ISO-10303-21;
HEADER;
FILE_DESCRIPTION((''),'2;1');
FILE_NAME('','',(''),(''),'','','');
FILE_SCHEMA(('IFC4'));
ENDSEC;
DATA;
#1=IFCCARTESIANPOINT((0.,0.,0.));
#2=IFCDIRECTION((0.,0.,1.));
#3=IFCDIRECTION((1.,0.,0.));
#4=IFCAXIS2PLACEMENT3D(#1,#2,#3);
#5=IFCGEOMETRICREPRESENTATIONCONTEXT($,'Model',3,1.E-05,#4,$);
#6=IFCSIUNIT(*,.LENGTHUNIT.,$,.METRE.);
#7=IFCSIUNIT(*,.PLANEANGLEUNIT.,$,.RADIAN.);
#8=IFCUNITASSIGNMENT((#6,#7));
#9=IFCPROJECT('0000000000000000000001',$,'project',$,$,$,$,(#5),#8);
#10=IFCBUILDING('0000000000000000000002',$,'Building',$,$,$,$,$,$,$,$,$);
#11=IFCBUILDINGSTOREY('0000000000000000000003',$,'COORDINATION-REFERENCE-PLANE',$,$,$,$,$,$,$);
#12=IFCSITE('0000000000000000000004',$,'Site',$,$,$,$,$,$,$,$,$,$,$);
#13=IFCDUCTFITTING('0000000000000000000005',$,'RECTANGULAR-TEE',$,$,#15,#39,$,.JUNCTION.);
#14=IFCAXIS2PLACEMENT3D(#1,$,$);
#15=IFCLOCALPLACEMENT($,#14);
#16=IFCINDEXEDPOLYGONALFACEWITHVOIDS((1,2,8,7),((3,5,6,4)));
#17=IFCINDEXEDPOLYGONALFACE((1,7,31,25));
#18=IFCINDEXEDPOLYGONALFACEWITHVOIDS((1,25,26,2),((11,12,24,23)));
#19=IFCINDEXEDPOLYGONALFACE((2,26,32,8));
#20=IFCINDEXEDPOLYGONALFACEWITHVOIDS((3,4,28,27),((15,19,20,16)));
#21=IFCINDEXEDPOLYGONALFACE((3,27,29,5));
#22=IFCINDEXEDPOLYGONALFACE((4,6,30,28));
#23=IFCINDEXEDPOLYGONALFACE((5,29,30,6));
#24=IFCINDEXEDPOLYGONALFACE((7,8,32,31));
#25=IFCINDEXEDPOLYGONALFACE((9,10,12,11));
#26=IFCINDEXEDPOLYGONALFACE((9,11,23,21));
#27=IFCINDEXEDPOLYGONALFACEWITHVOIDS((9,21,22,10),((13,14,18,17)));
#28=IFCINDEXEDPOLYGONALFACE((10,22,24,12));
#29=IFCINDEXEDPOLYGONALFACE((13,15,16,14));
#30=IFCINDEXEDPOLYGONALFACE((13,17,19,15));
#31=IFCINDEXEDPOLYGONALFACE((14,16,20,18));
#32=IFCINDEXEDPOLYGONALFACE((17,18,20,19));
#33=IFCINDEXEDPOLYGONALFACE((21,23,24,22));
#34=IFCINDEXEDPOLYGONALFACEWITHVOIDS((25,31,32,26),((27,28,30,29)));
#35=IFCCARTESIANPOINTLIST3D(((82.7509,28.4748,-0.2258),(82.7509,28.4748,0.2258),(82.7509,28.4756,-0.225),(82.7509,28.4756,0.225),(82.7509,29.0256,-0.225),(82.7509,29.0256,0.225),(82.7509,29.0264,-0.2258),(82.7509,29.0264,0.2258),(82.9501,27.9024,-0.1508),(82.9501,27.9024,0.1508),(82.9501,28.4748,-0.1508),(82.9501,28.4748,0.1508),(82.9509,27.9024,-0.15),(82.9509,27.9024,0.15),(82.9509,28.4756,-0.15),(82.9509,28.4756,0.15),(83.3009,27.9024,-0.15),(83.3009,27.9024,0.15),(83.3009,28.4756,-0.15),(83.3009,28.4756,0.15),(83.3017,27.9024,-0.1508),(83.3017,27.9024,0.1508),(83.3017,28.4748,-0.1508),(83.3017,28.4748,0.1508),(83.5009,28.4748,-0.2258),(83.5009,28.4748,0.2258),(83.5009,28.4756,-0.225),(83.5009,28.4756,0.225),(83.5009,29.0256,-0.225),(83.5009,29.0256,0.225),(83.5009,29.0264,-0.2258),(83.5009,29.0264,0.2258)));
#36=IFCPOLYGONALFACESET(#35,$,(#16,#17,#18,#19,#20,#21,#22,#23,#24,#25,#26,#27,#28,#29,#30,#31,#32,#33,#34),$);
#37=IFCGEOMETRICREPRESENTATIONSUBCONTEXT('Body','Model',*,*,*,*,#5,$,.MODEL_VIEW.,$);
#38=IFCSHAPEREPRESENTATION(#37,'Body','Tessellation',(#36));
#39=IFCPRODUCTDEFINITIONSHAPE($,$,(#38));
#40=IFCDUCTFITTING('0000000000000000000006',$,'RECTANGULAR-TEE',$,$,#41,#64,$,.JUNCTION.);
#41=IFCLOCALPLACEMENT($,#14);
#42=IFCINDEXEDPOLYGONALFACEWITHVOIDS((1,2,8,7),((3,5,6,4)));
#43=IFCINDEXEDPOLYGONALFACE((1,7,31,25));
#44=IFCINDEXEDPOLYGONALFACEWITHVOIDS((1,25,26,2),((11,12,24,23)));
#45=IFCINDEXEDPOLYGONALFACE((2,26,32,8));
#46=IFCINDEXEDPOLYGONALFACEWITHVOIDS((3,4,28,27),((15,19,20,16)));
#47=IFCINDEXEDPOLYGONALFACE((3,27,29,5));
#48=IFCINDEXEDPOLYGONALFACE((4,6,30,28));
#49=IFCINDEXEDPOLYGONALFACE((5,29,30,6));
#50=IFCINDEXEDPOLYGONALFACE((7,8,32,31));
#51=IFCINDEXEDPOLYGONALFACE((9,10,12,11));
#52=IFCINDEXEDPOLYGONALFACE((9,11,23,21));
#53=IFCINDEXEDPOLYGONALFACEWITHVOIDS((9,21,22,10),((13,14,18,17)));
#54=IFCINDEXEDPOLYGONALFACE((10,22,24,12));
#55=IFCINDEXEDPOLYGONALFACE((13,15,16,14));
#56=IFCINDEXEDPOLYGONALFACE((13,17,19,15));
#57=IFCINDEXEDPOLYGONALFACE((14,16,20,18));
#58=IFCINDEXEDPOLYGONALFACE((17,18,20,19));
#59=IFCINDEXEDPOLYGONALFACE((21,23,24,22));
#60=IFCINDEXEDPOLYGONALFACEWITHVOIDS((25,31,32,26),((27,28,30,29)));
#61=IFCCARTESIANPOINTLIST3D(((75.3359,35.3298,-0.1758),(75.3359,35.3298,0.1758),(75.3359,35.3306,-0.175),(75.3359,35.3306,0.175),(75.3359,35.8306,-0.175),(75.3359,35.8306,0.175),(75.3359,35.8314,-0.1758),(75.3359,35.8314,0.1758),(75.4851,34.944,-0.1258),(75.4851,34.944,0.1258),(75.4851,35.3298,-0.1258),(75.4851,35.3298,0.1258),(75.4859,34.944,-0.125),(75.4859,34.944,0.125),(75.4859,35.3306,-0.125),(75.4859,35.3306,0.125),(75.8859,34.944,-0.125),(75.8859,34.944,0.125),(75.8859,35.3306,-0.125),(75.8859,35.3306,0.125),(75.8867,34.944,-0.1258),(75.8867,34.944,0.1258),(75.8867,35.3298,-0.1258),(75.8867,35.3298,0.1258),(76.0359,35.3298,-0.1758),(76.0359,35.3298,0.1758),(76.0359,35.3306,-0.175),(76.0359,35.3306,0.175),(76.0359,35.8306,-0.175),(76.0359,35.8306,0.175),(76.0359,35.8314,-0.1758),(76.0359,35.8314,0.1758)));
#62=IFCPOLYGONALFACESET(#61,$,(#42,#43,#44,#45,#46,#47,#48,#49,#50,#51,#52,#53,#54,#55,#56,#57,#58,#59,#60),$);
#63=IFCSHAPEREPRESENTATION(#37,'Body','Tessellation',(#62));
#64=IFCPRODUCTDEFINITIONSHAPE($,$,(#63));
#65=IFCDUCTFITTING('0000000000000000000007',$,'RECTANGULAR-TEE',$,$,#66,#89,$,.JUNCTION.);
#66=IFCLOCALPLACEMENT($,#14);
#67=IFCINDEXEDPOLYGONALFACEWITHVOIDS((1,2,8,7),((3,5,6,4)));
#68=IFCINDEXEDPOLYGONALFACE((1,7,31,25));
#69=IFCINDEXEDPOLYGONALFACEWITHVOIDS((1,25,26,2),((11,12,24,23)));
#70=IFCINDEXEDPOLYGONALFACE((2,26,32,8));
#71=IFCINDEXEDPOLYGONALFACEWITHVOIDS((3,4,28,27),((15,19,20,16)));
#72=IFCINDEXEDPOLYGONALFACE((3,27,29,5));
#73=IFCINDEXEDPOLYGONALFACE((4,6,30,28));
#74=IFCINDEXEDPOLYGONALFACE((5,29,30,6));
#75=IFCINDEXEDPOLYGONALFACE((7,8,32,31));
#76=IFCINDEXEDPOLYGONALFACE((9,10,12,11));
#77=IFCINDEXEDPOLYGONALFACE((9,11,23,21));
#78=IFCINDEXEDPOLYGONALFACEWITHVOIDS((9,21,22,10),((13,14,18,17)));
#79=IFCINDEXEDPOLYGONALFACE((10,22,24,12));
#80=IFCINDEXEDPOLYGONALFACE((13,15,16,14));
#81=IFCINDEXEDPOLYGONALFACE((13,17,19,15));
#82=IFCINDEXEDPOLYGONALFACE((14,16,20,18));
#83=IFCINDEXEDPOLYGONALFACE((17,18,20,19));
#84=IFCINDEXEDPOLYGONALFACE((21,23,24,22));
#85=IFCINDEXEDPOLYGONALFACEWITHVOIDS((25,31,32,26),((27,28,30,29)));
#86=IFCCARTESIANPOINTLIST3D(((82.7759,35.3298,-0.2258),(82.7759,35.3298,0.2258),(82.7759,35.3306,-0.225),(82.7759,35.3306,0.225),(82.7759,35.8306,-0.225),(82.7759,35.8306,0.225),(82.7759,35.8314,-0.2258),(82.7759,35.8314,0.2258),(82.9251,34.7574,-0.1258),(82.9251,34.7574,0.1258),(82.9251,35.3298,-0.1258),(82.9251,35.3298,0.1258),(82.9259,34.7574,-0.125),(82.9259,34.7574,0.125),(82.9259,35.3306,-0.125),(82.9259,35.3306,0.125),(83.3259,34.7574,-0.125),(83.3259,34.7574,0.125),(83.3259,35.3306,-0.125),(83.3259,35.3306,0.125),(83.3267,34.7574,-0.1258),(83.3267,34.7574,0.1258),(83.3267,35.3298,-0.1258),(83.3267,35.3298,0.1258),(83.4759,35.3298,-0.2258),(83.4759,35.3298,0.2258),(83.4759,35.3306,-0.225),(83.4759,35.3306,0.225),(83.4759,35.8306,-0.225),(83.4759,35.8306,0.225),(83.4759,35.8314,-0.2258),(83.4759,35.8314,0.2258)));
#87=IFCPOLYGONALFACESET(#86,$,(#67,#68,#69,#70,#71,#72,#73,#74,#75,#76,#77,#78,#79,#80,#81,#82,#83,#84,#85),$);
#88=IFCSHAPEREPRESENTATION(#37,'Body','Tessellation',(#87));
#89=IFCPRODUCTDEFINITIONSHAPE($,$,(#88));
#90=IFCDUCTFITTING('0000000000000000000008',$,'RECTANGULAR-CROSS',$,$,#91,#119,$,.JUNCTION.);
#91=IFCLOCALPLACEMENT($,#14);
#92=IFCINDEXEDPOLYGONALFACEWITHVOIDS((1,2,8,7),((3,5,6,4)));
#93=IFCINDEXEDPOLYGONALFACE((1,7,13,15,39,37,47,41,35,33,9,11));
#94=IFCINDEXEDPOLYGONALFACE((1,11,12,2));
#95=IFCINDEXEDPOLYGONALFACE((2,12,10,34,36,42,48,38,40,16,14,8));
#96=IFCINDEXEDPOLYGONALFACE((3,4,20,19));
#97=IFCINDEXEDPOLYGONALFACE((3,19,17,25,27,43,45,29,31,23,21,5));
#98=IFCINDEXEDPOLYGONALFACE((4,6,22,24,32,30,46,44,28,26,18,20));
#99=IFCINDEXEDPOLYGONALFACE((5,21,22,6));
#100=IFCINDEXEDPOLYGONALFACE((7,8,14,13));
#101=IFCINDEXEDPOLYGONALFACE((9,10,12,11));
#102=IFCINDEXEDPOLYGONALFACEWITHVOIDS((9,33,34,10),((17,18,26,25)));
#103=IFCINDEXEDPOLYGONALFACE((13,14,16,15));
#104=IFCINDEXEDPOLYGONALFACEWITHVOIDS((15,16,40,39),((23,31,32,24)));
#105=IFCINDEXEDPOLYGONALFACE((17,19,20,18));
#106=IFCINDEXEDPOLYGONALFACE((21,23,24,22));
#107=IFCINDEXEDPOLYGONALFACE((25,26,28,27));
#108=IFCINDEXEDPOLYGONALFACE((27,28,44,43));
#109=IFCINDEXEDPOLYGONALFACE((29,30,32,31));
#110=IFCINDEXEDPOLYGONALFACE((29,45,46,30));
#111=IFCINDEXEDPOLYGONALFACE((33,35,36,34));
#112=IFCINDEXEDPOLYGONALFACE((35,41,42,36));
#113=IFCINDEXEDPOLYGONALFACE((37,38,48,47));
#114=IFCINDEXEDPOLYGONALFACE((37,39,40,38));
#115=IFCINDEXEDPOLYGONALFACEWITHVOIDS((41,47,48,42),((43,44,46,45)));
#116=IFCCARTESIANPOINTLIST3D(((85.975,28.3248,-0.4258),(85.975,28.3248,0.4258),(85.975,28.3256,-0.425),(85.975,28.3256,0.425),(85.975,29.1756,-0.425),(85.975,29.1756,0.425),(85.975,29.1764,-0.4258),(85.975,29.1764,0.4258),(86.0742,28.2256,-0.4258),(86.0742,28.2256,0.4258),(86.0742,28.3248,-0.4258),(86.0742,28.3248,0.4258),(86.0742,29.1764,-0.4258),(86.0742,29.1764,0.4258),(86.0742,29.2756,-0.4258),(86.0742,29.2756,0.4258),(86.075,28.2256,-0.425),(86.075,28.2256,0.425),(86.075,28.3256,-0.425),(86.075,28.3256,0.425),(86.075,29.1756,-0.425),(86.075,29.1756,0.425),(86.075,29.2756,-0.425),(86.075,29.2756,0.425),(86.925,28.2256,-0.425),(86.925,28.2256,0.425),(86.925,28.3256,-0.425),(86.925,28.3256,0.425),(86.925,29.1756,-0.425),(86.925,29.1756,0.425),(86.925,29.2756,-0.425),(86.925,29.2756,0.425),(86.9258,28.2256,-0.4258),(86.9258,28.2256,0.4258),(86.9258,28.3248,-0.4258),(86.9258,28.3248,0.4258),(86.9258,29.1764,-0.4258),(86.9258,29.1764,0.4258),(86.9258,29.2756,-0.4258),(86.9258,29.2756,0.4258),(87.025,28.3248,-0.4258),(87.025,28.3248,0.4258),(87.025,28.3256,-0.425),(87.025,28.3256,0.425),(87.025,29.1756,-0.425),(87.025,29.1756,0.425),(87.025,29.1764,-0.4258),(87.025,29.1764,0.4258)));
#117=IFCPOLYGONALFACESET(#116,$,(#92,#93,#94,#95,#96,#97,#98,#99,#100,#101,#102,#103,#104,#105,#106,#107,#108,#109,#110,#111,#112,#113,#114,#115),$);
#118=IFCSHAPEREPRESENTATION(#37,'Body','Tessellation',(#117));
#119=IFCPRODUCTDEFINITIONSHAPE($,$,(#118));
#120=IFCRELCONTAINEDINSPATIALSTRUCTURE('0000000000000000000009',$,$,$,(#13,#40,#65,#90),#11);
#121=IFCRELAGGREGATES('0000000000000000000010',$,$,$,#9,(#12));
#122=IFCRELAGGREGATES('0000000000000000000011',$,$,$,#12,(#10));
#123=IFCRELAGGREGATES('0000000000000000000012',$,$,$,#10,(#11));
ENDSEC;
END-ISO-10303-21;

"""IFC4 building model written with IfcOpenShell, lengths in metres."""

from ifc_helpers import new_model, si_unit, frame, origin_with_axes, place, context, subcontext, project, spatial, rectangle, extrude, boolean, element, save


model = new_model("IFC4")

# Units and contexts
model_context = context("Model", 3, precision=1e-05, world=origin_with_axes())
body_context = subcontext(model_context, "Body", "Model", "MODEL_VIEW")
ifc_project = project(units=[si_unit("LENGTHUNIT", "METRE"), si_unit("PLANEANGLEUNIT", "RADIAN")], contexts=[model_context])

# Site, building, storey
site = spatial("IfcSite", under=ifc_project, Name="Site")
building = spatial("IfcBuilding", under=site, Name="Building")
storey = spatial("IfcBuildingStorey", under=building, Name="COORDINATION-REFERENCE-PLANE")

# Duct fittings
duct_fitting_1_placement = place(None, frame((83.1259, 28.7506, 0.0), z_axis=(-1.0, 0.0, 0.0), x_axis=(0.0, -1.0, 0.0)))
solid_1 = boolean("UNION", extrude(rectangle(XDim=0.55, YDim=0.45), frame((0.0, 0.0, -0.375), z_axis=(0.0, 0.0, 1.0), x_axis=(1.0, 0.0, 0.0)), (0.0, 0.0, 1.0), 0.75), extrude(rectangle(XDim=0.35, YDim=0.3), frame((0.0, 0.0, 0.0), z_axis=(1.0, 0.0, 0.0), x_axis=(0.0, 0.0, -1.0)), (0.0, 0.0, 1.0), 0.8482))
element("IfcDuctFitting", 1, at=duct_fitting_1_placement, inside=storey, Name="RECTANGULAR-TEE", PredefinedType="JUNCTION", context=body_context, shape_type="CSG", body=[
    boolean("DIFFERENCE", boolean("UNION", extrude(rectangle(XDim=0.5516, YDim=0.4516), frame((0.0, 0.0, -0.375), z_axis=(0.0, 0.0, 1.0), x_axis=(1.0, 0.0, 0.0)), (0.0, 0.0, 1.0), 0.75), extrude(rectangle(XDim=0.3516, YDim=0.3016), frame((0.0, 0.0, 0.0), z_axis=(1.0, 0.0, 0.0), x_axis=(0.0, 0.0, -1.0)), (0.0, 0.0, 1.0), 0.8482)), solid_1),
])
duct_fitting_2_placement = place(None, frame((75.6859, 35.5806, 0.0), z_axis=(-1.0, 0.0, 0.0), x_axis=(0.0, -1.0, 0.0)))
solid_2 = boolean("UNION", extrude(rectangle(XDim=0.5, YDim=0.35), frame((0.0, 0.0, -0.35), z_axis=(0.0, 0.0, 1.0), x_axis=(1.0, 0.0, 0.0)), (0.0, 0.0, 1.0), 0.7), extrude(rectangle(XDim=0.4, YDim=0.25), frame((0.0, 0.0, 0.0), z_axis=(1.0, 0.0, 0.0), x_axis=(0.0, 0.0, -1.0)), (0.0, 0.0, 1.0), 0.6366))
element("IfcDuctFitting", 2, at=duct_fitting_2_placement, inside=storey, Name="RECTANGULAR-TEE", PredefinedType="JUNCTION", context=body_context, shape_type="CSG", body=[
    boolean("DIFFERENCE", boolean("UNION", extrude(rectangle(XDim=0.5016, YDim=0.3516), frame((0.0, 0.0, -0.35), z_axis=(0.0, 0.0, 1.0), x_axis=(1.0, 0.0, 0.0)), (0.0, 0.0, 1.0), 0.7), extrude(rectangle(XDim=0.4016, YDim=0.2516), frame((0.0, 0.0, 0.0), z_axis=(1.0, 0.0, 0.0), x_axis=(0.0, 0.0, -1.0)), (0.0, 0.0, 1.0), 0.6366)), solid_2),
])
duct_fitting_3_placement = place(None, frame((83.1259, 35.5806, 0.0), z_axis=(-1.0, 0.0, 0.0), x_axis=(0.0, -1.0, 0.0)))
solid_3 = boolean("UNION", extrude(rectangle(XDim=0.5, YDim=0.45), frame((0.0, 0.0, -0.35), z_axis=(0.0, 0.0, 1.0), x_axis=(1.0, 0.0, 0.0)), (0.0, 0.0, 1.0), 0.7), extrude(rectangle(XDim=0.4, YDim=0.25), frame((0.0, 0.0, 0.0), z_axis=(1.0, 0.0, 0.0), x_axis=(0.0, 0.0, -1.0)), (0.0, 0.0, 1.0), 0.8232))
element("IfcDuctFitting", 3, at=duct_fitting_3_placement, inside=storey, Name="RECTANGULAR-TEE", PredefinedType="JUNCTION", context=body_context, shape_type="CSG", body=[
    boolean("DIFFERENCE", boolean("UNION", extrude(rectangle(XDim=0.5016, YDim=0.4516), frame((0.0, 0.0, -0.35), z_axis=(0.0, 0.0, 1.0), x_axis=(1.0, 0.0, 0.0)), (0.0, 0.0, 1.0), 0.7), extrude(rectangle(XDim=0.4016, YDim=0.2516), frame((0.0, 0.0, 0.0), z_axis=(1.0, 0.0, 0.0), x_axis=(0.0, 0.0, -1.0)), (0.0, 0.0, 1.0), 0.8232)), solid_3),
])
duct_fitting_4_placement = place(None, frame((86.5, 28.7506, 0.0), z_axis=(0.0, -1.0, 0.0), x_axis=(1.0, 0.0, 0.0)))
solid_4 = boolean("UNION", extrude(rectangle(XDim=0.85, YDim=0.85), frame((0.0, 0.0, -0.525), z_axis=(0.0, 0.0, 1.0), x_axis=(1.0, 0.0, 0.0)), (0.0, 0.0, 1.0), 1.05), extrude(rectangle(XDim=0.85, YDim=0.85), frame((-0.525, 0.0, 0.0), z_axis=(1.0, 0.0, 0.0), x_axis=(0.0, 0.0, -1.0)), (0.0, 0.0, 1.0), 1.05))
element("IfcDuctFitting", 4, at=duct_fitting_4_placement, inside=storey, Name="RECTANGULAR-CROSS", PredefinedType="JUNCTION", context=body_context, shape_type="CSG", body=[
    boolean("DIFFERENCE", boolean("UNION", extrude(rectangle(XDim=0.8516, YDim=0.8516), frame((0.0, 0.0, -0.525), z_axis=(0.0, 0.0, 1.0), x_axis=(1.0, 0.0, 0.0)), (0.0, 0.0, 1.0), 1.05), extrude(rectangle(XDim=0.8516, YDim=0.8516), frame((-0.525, 0.0, 0.0), z_axis=(1.0, 0.0, 0.0), x_axis=(0.0, 0.0, -1.0)), (0.0, 0.0, 1.0), 1.05)), solid_4),
])

save(model, "model.ifc")
